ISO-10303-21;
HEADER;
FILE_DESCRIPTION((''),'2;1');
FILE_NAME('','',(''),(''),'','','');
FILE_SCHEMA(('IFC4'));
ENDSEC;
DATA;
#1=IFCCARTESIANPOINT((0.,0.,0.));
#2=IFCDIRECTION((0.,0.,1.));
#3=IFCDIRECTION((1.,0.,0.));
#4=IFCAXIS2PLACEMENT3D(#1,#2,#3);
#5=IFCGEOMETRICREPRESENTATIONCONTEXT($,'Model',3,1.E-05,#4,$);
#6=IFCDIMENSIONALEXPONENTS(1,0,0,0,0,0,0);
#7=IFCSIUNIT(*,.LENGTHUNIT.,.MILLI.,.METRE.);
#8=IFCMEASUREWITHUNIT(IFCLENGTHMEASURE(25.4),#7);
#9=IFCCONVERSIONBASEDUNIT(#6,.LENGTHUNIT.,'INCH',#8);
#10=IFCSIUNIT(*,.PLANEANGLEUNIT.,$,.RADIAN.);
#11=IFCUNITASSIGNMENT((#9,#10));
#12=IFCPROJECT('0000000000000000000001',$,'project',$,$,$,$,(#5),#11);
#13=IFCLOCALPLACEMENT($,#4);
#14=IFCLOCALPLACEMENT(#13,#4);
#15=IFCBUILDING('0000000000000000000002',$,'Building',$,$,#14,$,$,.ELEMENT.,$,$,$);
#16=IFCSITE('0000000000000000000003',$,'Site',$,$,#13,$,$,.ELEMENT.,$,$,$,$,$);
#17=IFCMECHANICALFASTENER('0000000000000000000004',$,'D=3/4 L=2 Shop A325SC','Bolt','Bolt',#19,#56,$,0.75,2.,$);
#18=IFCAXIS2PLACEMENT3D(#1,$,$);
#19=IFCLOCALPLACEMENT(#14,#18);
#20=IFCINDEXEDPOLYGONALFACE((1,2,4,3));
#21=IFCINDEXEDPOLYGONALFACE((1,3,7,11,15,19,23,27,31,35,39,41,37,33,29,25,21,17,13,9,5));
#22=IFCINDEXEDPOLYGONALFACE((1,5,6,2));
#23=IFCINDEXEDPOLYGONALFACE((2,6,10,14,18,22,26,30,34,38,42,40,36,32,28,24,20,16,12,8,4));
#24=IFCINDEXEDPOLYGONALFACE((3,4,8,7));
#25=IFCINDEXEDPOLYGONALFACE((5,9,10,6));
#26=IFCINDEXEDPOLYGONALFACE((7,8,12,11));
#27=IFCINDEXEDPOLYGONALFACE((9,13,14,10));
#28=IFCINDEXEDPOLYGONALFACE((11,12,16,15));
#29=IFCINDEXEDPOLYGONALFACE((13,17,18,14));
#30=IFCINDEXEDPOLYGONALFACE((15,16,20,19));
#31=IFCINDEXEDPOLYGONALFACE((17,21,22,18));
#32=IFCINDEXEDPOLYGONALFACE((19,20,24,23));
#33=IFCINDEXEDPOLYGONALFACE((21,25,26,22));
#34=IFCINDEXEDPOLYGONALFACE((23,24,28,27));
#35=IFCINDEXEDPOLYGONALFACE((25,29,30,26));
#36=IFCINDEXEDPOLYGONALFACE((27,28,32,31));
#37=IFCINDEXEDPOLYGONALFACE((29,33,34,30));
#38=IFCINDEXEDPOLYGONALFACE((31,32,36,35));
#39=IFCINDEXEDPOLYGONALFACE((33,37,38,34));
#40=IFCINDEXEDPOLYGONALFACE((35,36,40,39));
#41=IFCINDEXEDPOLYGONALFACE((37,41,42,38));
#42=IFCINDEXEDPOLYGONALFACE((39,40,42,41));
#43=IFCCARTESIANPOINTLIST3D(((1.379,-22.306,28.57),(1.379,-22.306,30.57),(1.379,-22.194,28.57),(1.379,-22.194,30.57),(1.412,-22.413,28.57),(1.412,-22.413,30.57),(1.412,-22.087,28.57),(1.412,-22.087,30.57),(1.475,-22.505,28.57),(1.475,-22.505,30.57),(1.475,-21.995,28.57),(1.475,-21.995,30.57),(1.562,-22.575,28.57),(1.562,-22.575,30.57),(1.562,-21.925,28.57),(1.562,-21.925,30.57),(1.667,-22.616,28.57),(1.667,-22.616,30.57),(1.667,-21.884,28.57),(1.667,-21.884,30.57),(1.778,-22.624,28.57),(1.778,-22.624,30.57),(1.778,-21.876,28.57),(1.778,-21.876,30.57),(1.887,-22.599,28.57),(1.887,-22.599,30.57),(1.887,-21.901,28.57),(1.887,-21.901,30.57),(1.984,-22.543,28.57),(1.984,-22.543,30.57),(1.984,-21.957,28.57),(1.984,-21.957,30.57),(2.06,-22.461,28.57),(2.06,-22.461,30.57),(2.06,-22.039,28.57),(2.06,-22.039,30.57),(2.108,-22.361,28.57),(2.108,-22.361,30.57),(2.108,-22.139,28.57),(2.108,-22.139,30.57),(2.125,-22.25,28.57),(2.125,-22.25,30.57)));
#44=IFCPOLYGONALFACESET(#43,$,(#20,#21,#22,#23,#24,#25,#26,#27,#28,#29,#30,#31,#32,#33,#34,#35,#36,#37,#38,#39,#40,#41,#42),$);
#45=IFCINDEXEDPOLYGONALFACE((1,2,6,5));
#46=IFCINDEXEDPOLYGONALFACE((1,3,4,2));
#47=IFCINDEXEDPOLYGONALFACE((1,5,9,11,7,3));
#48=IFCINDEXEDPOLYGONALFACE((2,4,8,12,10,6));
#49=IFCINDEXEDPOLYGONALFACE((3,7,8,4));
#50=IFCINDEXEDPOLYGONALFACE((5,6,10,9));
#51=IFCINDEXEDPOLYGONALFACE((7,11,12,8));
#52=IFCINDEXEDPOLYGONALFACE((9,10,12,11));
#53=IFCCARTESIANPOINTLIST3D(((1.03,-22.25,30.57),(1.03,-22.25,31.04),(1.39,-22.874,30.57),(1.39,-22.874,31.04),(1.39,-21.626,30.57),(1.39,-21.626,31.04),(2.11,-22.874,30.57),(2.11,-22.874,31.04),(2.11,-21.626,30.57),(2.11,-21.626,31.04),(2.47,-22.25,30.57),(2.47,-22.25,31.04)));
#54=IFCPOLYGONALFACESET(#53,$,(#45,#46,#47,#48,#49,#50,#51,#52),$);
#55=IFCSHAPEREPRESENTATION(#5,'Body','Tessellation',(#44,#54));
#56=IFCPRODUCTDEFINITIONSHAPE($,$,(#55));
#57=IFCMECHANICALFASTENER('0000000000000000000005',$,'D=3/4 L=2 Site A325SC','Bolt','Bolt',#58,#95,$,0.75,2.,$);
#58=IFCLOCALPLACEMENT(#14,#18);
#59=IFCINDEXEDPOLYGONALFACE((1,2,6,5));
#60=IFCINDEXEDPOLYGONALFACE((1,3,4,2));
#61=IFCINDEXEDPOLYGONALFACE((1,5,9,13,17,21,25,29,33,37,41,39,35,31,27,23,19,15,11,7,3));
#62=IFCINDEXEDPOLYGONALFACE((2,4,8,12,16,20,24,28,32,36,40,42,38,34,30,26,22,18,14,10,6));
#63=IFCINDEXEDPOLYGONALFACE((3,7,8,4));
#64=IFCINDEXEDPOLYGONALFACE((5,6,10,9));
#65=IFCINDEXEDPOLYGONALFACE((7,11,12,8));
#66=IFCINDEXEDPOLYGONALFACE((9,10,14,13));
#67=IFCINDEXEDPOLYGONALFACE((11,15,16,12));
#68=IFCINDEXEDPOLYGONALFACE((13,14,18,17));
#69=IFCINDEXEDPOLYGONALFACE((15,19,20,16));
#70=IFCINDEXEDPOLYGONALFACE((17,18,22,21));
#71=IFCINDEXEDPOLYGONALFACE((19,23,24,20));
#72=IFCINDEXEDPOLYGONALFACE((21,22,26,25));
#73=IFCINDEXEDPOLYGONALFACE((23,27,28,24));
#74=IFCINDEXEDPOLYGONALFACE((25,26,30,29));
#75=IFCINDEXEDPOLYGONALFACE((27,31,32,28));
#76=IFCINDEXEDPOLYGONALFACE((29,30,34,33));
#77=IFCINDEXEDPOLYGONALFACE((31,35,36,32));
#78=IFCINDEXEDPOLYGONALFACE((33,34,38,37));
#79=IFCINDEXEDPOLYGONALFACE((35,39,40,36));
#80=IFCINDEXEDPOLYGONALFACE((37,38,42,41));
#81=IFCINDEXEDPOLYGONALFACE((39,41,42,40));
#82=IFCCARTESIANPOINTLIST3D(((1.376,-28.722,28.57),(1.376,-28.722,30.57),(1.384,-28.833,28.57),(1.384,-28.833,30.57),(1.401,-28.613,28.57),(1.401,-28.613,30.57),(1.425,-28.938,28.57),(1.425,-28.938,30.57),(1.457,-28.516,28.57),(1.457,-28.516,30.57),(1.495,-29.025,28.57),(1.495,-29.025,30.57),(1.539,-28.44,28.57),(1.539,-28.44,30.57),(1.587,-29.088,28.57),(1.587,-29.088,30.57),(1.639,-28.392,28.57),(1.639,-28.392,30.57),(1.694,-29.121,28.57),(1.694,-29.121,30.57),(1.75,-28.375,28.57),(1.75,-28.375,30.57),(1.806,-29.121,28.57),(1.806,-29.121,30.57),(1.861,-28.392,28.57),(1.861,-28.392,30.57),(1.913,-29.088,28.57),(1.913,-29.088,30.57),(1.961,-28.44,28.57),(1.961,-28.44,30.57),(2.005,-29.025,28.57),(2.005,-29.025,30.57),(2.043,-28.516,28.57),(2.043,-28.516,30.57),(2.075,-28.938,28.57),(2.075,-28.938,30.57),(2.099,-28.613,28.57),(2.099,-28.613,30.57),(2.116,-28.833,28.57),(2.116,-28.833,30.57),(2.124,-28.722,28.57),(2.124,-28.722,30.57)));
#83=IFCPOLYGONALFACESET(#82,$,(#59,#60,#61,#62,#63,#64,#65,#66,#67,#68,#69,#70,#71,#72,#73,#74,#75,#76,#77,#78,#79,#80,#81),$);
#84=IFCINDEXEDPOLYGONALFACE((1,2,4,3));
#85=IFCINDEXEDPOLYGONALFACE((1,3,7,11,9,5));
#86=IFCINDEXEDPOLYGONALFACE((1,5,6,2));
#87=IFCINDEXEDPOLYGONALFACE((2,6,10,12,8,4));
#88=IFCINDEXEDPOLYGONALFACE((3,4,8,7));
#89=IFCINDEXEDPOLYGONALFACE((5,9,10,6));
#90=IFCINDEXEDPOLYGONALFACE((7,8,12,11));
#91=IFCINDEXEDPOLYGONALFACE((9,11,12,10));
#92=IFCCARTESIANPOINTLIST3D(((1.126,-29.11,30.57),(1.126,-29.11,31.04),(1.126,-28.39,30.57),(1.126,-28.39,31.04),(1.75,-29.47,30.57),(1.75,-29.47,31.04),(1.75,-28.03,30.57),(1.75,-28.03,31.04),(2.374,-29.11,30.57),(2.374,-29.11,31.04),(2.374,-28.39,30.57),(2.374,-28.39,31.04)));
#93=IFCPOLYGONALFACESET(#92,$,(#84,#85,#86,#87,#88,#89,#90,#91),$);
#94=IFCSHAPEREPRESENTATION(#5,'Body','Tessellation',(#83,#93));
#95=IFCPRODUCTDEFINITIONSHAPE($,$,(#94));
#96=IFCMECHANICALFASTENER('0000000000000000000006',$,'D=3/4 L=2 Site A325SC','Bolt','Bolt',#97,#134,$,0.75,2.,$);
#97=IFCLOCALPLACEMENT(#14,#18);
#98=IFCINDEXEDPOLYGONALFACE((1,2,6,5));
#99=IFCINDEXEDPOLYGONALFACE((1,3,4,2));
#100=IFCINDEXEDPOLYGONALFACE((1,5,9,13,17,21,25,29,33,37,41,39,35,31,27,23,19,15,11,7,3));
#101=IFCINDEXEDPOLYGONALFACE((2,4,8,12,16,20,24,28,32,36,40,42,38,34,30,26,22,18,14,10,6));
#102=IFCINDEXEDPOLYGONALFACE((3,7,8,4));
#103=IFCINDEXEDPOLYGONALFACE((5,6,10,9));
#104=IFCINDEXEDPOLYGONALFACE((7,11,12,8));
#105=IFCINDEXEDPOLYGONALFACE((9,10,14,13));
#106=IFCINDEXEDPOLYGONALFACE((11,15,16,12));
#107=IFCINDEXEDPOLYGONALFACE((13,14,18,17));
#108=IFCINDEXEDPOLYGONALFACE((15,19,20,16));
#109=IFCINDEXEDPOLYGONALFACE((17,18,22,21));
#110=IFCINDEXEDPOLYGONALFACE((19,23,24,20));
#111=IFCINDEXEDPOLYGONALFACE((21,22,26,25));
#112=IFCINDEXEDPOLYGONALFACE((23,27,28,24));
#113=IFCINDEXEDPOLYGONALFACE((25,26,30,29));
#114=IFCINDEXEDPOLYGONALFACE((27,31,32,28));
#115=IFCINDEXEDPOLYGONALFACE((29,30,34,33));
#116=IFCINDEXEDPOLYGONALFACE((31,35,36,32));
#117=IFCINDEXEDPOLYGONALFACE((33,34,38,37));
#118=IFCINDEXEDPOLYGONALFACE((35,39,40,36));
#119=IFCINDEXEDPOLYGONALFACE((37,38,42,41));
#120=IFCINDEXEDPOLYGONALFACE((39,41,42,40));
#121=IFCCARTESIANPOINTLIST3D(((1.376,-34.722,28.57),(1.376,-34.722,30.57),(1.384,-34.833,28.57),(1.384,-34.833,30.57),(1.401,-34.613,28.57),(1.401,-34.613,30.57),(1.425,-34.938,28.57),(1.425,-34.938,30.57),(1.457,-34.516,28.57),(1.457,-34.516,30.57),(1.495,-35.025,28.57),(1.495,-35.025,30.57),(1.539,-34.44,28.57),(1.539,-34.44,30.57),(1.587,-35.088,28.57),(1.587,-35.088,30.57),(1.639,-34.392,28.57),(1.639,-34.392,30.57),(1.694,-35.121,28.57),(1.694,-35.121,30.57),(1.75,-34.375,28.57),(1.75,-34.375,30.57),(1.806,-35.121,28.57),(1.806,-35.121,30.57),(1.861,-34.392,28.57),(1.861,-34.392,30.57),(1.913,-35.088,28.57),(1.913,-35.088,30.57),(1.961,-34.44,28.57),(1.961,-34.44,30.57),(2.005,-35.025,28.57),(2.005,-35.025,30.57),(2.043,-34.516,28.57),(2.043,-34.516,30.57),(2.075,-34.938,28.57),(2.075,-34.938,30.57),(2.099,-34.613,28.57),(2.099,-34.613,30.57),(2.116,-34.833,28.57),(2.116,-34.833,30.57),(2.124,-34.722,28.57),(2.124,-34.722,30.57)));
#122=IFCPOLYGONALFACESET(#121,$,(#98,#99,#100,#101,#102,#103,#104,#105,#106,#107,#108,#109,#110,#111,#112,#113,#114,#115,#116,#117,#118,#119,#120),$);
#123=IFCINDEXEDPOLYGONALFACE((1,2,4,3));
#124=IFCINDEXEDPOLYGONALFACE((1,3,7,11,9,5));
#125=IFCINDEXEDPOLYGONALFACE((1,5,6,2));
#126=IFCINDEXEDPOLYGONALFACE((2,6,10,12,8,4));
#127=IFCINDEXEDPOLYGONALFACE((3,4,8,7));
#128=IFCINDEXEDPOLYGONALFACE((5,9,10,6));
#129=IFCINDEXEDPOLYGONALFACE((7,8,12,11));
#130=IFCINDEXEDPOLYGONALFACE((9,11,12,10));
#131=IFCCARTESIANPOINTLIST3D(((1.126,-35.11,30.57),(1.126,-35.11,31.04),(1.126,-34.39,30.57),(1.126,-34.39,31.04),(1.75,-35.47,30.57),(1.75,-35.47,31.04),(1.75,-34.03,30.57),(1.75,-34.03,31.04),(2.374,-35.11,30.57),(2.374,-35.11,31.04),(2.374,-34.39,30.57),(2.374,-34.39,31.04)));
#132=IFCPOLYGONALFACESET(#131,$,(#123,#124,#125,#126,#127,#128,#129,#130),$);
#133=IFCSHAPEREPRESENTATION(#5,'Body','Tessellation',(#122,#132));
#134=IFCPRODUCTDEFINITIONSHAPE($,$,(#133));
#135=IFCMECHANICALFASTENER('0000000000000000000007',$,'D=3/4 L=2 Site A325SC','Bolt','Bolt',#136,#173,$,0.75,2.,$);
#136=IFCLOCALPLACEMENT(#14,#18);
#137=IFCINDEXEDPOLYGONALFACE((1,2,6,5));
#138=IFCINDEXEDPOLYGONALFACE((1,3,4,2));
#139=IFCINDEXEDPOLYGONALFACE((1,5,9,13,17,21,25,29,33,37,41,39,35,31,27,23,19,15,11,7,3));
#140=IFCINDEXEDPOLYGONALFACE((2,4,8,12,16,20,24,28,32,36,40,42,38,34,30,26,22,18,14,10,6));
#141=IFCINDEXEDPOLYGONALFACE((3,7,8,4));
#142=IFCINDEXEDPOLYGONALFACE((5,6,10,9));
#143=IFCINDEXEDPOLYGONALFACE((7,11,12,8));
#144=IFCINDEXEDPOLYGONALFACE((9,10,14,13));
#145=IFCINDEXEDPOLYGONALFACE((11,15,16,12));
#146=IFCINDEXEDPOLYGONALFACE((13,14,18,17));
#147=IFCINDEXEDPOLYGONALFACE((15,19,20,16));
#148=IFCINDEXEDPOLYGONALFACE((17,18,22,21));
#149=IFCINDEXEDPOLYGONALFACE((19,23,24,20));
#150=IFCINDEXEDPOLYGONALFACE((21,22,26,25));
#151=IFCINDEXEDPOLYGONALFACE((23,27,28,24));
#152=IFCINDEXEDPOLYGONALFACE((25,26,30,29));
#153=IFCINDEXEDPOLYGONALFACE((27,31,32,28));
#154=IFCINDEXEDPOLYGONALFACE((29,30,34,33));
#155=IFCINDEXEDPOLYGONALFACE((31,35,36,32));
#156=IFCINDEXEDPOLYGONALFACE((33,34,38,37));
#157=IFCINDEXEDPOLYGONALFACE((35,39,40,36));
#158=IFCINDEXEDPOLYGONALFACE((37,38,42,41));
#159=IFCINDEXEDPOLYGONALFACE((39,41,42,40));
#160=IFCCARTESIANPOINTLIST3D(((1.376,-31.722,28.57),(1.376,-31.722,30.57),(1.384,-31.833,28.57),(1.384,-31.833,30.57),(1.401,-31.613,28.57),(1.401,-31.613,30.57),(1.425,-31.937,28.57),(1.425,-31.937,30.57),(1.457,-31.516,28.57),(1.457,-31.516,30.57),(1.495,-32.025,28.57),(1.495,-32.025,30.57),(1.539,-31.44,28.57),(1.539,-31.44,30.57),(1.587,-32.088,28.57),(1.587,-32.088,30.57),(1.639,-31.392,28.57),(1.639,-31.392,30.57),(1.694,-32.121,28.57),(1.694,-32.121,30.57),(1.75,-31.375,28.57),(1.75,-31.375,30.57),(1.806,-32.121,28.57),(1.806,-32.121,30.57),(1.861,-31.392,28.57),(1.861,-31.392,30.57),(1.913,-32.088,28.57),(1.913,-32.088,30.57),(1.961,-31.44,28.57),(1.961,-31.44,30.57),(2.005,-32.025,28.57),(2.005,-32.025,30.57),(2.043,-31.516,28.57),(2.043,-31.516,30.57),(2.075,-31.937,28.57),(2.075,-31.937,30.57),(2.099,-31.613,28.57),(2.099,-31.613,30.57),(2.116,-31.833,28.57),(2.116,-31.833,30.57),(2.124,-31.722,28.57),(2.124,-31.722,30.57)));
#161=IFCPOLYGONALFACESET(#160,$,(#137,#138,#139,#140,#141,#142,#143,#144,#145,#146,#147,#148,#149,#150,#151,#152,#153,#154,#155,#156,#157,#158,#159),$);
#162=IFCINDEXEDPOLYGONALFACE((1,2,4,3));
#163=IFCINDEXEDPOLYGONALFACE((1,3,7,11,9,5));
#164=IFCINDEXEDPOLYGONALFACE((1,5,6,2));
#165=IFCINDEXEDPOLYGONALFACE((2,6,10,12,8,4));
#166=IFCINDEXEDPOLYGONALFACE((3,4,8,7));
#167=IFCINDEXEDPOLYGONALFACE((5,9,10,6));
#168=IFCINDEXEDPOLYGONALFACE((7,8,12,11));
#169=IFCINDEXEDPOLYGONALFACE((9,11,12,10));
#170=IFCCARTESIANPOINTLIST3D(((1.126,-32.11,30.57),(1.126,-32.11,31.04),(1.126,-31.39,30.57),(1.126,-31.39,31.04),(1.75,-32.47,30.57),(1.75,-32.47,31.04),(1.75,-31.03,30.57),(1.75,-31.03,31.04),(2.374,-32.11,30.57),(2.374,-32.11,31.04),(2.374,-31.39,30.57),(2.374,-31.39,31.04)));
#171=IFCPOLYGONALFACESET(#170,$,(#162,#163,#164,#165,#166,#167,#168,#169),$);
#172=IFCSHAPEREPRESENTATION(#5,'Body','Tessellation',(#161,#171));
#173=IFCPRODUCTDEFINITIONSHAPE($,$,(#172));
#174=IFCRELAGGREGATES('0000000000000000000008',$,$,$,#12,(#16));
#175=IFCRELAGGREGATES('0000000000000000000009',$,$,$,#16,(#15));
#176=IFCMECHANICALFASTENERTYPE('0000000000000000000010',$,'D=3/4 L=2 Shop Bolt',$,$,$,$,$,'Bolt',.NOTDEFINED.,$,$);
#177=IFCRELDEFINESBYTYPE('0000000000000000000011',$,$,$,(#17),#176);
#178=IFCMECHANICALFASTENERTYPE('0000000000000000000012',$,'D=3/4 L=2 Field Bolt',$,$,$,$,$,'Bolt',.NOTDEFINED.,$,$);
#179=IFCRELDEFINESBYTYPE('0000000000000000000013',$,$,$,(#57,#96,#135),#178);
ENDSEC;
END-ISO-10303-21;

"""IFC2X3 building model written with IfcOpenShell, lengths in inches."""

from ifc_helpers import new_model, entity, si_unit, converted_unit, frame, origin_with_axes, origin_2d_with_axis, place, context, project, spatial, polyline, circle, outline, extrude, source, transform, mapped, type_object, type_shapes, element, save


model = new_model("IFC2X3")

# Units and contexts
model_context = context("Model", 3, precision=1e-05, world=origin_with_axes())
ifc_project = project(units=[converted_unit("LENGTHUNIT", "INCH", entity("IfcLengthMeasure", 25.4), si_unit("LENGTHUNIT", "METRE", prefix="MILLI"), dimensions=[1, 0, 0, 0, 0, 0, 0]), si_unit("PLANEANGLEUNIT", "RADIAN")], contexts=[model_context])

# Site, building
site_placement = place(None, origin_with_axes())
site = spatial("IfcSite", under=ifc_project, at=site_placement, Name="Site", CompositionType="ELEMENT")
building_placement = place(site_placement, origin_with_axes())
building = spatial("IfcBuilding", under=site, at=building_placement, Name="Building", CompositionType="ELEMENT")

# Shared definitions
assembly_1_placement = place(building_placement, frame((0.0, 0.0, 46.0), z_axis=(0.0, 0.0, 1.0), x_axis=(0.0, -1.0, 0.0)))

# Mechanical fasteners
mechanical_fastener_type_1 = type_object("IfcMechanicalFastenerType", Name="D=3/4 L=2 Shop Bolt", ElementType="Bolt")
shared_shape_1 = source(origin_with_axes(), model_context, "Body", "SweptSolid", [
    extrude(circle(Radius=0.375, at=origin_2d_with_axis()), frame((0.0, 0.0, 0.0), z_axis=(1.0, 0.0, 0.0), x_axis=(0.0, 1.0, 0.0)), (0.0, 0.0, 1.0), 2.0),
    extrude(outline(polyline([(-0.72, 0.0), (-0.36, 0.624), (0.36, 0.624), (0.72, 0.0), (0.36, -0.624), (-0.36, -0.624), (-0.72, 0.0)])), frame((0.0, 0.0, 0.0), z_axis=(1.0, 0.0, 0.0), x_axis=(0.0, 1.0, 0.0)), (0.0, 0.0, -1.0), 0.47),
])
type_shapes(mechanical_fastener_type_1, [shared_shape_1])
placement_1 = place(assembly_1_placement, frame((25.25, -1.75, -15.43), z_axis=(1.0, 0.0, 0.0), x_axis=(0.0, 0.0, -1.0)))
for number, where, z_axis, x_axis, name in (
    (1, (0.0, 3.5, -3.0), (0.0, 0.0, 1.0), (1.0, 0.0, 0.0), "D=3/4 L=2 Shop A325SC"),
):
    element("IfcMechanicalFastener", number, at=place(placement_1, frame(where, z_axis=z_axis, x_axis=x_axis)), type_object=mechanical_fastener_type_1, Name=name, Description="Bolt", ObjectType="Bolt", NominalDiameter=0.75, NominalLength=2.0, context=model_context, shape_type="MappedRepresentation", body=[
        mapped(shared_shape_1, transform((0.0, 0.0, 0.0), scale=1.0)),
    ])
mechanical_fastener_type_2 = type_object("IfcMechanicalFastenerType", Name="D=3/4 L=2 Field Bolt", ElementType="Bolt")
shared_shape_2 = source(origin_with_axes(), model_context, "Body", "SweptSolid", [
    extrude(circle(Radius=0.375, at=origin_2d_with_axis()), frame((0.0, 0.0, 0.0), z_axis=(1.0, 0.0, 0.0), x_axis=(0.0, 1.0, 0.0)), (0.0, 0.0, 1.0), 2.0),
    extrude(outline(polyline([(-0.72, 0.0), (-0.36, 0.624), (0.36, 0.624), (0.72, 0.0), (0.36, -0.624), (-0.36, -0.624), (-0.72, 0.0)])), frame((0.0, 0.0, 0.0), z_axis=(1.0, 0.0, 0.0), x_axis=(0.0, 1.0, 0.0)), (0.0, 0.0, -1.0), 0.47),
])
type_shapes(mechanical_fastener_type_2, [shared_shape_2])
placement_2 = place(assembly_1_placement, frame((28.75, -1.75, -15.43), z_axis=(0.0, 1.0, 0.0), x_axis=(0.0, 0.0, -1.0)))
for number, where, z_axis, x_axis, name in (
    (2, (0.0, 0.0, 3.5), (0.0, 0.0, 1.0), (1.0, 0.0, 0.0), "D=3/4 L=2 Site A325SC"),
    (3, (0.0, -6.0, 3.5), (0.0, 0.0, 1.0), (1.0, 0.0, 0.0), "D=3/4 L=2 Site A325SC"),
    (4, (0.0, -3.0, 3.5), (0.0, 0.0, 1.0), (1.0, 0.0, 0.0), "D=3/4 L=2 Site A325SC"),
):
    element("IfcMechanicalFastener", number, at=place(placement_2, frame(where, z_axis=z_axis, x_axis=x_axis)), type_object=mechanical_fastener_type_2, Name=name, Description="Bolt", ObjectType="Bolt", NominalDiameter=0.75, NominalLength=2.0, context=model_context, shape_type="MappedRepresentation", body=[
        mapped(shared_shape_2, transform((0.0, 0.0, 0.0), scale=1.0)),
    ])

save(model, "model.ifc")
